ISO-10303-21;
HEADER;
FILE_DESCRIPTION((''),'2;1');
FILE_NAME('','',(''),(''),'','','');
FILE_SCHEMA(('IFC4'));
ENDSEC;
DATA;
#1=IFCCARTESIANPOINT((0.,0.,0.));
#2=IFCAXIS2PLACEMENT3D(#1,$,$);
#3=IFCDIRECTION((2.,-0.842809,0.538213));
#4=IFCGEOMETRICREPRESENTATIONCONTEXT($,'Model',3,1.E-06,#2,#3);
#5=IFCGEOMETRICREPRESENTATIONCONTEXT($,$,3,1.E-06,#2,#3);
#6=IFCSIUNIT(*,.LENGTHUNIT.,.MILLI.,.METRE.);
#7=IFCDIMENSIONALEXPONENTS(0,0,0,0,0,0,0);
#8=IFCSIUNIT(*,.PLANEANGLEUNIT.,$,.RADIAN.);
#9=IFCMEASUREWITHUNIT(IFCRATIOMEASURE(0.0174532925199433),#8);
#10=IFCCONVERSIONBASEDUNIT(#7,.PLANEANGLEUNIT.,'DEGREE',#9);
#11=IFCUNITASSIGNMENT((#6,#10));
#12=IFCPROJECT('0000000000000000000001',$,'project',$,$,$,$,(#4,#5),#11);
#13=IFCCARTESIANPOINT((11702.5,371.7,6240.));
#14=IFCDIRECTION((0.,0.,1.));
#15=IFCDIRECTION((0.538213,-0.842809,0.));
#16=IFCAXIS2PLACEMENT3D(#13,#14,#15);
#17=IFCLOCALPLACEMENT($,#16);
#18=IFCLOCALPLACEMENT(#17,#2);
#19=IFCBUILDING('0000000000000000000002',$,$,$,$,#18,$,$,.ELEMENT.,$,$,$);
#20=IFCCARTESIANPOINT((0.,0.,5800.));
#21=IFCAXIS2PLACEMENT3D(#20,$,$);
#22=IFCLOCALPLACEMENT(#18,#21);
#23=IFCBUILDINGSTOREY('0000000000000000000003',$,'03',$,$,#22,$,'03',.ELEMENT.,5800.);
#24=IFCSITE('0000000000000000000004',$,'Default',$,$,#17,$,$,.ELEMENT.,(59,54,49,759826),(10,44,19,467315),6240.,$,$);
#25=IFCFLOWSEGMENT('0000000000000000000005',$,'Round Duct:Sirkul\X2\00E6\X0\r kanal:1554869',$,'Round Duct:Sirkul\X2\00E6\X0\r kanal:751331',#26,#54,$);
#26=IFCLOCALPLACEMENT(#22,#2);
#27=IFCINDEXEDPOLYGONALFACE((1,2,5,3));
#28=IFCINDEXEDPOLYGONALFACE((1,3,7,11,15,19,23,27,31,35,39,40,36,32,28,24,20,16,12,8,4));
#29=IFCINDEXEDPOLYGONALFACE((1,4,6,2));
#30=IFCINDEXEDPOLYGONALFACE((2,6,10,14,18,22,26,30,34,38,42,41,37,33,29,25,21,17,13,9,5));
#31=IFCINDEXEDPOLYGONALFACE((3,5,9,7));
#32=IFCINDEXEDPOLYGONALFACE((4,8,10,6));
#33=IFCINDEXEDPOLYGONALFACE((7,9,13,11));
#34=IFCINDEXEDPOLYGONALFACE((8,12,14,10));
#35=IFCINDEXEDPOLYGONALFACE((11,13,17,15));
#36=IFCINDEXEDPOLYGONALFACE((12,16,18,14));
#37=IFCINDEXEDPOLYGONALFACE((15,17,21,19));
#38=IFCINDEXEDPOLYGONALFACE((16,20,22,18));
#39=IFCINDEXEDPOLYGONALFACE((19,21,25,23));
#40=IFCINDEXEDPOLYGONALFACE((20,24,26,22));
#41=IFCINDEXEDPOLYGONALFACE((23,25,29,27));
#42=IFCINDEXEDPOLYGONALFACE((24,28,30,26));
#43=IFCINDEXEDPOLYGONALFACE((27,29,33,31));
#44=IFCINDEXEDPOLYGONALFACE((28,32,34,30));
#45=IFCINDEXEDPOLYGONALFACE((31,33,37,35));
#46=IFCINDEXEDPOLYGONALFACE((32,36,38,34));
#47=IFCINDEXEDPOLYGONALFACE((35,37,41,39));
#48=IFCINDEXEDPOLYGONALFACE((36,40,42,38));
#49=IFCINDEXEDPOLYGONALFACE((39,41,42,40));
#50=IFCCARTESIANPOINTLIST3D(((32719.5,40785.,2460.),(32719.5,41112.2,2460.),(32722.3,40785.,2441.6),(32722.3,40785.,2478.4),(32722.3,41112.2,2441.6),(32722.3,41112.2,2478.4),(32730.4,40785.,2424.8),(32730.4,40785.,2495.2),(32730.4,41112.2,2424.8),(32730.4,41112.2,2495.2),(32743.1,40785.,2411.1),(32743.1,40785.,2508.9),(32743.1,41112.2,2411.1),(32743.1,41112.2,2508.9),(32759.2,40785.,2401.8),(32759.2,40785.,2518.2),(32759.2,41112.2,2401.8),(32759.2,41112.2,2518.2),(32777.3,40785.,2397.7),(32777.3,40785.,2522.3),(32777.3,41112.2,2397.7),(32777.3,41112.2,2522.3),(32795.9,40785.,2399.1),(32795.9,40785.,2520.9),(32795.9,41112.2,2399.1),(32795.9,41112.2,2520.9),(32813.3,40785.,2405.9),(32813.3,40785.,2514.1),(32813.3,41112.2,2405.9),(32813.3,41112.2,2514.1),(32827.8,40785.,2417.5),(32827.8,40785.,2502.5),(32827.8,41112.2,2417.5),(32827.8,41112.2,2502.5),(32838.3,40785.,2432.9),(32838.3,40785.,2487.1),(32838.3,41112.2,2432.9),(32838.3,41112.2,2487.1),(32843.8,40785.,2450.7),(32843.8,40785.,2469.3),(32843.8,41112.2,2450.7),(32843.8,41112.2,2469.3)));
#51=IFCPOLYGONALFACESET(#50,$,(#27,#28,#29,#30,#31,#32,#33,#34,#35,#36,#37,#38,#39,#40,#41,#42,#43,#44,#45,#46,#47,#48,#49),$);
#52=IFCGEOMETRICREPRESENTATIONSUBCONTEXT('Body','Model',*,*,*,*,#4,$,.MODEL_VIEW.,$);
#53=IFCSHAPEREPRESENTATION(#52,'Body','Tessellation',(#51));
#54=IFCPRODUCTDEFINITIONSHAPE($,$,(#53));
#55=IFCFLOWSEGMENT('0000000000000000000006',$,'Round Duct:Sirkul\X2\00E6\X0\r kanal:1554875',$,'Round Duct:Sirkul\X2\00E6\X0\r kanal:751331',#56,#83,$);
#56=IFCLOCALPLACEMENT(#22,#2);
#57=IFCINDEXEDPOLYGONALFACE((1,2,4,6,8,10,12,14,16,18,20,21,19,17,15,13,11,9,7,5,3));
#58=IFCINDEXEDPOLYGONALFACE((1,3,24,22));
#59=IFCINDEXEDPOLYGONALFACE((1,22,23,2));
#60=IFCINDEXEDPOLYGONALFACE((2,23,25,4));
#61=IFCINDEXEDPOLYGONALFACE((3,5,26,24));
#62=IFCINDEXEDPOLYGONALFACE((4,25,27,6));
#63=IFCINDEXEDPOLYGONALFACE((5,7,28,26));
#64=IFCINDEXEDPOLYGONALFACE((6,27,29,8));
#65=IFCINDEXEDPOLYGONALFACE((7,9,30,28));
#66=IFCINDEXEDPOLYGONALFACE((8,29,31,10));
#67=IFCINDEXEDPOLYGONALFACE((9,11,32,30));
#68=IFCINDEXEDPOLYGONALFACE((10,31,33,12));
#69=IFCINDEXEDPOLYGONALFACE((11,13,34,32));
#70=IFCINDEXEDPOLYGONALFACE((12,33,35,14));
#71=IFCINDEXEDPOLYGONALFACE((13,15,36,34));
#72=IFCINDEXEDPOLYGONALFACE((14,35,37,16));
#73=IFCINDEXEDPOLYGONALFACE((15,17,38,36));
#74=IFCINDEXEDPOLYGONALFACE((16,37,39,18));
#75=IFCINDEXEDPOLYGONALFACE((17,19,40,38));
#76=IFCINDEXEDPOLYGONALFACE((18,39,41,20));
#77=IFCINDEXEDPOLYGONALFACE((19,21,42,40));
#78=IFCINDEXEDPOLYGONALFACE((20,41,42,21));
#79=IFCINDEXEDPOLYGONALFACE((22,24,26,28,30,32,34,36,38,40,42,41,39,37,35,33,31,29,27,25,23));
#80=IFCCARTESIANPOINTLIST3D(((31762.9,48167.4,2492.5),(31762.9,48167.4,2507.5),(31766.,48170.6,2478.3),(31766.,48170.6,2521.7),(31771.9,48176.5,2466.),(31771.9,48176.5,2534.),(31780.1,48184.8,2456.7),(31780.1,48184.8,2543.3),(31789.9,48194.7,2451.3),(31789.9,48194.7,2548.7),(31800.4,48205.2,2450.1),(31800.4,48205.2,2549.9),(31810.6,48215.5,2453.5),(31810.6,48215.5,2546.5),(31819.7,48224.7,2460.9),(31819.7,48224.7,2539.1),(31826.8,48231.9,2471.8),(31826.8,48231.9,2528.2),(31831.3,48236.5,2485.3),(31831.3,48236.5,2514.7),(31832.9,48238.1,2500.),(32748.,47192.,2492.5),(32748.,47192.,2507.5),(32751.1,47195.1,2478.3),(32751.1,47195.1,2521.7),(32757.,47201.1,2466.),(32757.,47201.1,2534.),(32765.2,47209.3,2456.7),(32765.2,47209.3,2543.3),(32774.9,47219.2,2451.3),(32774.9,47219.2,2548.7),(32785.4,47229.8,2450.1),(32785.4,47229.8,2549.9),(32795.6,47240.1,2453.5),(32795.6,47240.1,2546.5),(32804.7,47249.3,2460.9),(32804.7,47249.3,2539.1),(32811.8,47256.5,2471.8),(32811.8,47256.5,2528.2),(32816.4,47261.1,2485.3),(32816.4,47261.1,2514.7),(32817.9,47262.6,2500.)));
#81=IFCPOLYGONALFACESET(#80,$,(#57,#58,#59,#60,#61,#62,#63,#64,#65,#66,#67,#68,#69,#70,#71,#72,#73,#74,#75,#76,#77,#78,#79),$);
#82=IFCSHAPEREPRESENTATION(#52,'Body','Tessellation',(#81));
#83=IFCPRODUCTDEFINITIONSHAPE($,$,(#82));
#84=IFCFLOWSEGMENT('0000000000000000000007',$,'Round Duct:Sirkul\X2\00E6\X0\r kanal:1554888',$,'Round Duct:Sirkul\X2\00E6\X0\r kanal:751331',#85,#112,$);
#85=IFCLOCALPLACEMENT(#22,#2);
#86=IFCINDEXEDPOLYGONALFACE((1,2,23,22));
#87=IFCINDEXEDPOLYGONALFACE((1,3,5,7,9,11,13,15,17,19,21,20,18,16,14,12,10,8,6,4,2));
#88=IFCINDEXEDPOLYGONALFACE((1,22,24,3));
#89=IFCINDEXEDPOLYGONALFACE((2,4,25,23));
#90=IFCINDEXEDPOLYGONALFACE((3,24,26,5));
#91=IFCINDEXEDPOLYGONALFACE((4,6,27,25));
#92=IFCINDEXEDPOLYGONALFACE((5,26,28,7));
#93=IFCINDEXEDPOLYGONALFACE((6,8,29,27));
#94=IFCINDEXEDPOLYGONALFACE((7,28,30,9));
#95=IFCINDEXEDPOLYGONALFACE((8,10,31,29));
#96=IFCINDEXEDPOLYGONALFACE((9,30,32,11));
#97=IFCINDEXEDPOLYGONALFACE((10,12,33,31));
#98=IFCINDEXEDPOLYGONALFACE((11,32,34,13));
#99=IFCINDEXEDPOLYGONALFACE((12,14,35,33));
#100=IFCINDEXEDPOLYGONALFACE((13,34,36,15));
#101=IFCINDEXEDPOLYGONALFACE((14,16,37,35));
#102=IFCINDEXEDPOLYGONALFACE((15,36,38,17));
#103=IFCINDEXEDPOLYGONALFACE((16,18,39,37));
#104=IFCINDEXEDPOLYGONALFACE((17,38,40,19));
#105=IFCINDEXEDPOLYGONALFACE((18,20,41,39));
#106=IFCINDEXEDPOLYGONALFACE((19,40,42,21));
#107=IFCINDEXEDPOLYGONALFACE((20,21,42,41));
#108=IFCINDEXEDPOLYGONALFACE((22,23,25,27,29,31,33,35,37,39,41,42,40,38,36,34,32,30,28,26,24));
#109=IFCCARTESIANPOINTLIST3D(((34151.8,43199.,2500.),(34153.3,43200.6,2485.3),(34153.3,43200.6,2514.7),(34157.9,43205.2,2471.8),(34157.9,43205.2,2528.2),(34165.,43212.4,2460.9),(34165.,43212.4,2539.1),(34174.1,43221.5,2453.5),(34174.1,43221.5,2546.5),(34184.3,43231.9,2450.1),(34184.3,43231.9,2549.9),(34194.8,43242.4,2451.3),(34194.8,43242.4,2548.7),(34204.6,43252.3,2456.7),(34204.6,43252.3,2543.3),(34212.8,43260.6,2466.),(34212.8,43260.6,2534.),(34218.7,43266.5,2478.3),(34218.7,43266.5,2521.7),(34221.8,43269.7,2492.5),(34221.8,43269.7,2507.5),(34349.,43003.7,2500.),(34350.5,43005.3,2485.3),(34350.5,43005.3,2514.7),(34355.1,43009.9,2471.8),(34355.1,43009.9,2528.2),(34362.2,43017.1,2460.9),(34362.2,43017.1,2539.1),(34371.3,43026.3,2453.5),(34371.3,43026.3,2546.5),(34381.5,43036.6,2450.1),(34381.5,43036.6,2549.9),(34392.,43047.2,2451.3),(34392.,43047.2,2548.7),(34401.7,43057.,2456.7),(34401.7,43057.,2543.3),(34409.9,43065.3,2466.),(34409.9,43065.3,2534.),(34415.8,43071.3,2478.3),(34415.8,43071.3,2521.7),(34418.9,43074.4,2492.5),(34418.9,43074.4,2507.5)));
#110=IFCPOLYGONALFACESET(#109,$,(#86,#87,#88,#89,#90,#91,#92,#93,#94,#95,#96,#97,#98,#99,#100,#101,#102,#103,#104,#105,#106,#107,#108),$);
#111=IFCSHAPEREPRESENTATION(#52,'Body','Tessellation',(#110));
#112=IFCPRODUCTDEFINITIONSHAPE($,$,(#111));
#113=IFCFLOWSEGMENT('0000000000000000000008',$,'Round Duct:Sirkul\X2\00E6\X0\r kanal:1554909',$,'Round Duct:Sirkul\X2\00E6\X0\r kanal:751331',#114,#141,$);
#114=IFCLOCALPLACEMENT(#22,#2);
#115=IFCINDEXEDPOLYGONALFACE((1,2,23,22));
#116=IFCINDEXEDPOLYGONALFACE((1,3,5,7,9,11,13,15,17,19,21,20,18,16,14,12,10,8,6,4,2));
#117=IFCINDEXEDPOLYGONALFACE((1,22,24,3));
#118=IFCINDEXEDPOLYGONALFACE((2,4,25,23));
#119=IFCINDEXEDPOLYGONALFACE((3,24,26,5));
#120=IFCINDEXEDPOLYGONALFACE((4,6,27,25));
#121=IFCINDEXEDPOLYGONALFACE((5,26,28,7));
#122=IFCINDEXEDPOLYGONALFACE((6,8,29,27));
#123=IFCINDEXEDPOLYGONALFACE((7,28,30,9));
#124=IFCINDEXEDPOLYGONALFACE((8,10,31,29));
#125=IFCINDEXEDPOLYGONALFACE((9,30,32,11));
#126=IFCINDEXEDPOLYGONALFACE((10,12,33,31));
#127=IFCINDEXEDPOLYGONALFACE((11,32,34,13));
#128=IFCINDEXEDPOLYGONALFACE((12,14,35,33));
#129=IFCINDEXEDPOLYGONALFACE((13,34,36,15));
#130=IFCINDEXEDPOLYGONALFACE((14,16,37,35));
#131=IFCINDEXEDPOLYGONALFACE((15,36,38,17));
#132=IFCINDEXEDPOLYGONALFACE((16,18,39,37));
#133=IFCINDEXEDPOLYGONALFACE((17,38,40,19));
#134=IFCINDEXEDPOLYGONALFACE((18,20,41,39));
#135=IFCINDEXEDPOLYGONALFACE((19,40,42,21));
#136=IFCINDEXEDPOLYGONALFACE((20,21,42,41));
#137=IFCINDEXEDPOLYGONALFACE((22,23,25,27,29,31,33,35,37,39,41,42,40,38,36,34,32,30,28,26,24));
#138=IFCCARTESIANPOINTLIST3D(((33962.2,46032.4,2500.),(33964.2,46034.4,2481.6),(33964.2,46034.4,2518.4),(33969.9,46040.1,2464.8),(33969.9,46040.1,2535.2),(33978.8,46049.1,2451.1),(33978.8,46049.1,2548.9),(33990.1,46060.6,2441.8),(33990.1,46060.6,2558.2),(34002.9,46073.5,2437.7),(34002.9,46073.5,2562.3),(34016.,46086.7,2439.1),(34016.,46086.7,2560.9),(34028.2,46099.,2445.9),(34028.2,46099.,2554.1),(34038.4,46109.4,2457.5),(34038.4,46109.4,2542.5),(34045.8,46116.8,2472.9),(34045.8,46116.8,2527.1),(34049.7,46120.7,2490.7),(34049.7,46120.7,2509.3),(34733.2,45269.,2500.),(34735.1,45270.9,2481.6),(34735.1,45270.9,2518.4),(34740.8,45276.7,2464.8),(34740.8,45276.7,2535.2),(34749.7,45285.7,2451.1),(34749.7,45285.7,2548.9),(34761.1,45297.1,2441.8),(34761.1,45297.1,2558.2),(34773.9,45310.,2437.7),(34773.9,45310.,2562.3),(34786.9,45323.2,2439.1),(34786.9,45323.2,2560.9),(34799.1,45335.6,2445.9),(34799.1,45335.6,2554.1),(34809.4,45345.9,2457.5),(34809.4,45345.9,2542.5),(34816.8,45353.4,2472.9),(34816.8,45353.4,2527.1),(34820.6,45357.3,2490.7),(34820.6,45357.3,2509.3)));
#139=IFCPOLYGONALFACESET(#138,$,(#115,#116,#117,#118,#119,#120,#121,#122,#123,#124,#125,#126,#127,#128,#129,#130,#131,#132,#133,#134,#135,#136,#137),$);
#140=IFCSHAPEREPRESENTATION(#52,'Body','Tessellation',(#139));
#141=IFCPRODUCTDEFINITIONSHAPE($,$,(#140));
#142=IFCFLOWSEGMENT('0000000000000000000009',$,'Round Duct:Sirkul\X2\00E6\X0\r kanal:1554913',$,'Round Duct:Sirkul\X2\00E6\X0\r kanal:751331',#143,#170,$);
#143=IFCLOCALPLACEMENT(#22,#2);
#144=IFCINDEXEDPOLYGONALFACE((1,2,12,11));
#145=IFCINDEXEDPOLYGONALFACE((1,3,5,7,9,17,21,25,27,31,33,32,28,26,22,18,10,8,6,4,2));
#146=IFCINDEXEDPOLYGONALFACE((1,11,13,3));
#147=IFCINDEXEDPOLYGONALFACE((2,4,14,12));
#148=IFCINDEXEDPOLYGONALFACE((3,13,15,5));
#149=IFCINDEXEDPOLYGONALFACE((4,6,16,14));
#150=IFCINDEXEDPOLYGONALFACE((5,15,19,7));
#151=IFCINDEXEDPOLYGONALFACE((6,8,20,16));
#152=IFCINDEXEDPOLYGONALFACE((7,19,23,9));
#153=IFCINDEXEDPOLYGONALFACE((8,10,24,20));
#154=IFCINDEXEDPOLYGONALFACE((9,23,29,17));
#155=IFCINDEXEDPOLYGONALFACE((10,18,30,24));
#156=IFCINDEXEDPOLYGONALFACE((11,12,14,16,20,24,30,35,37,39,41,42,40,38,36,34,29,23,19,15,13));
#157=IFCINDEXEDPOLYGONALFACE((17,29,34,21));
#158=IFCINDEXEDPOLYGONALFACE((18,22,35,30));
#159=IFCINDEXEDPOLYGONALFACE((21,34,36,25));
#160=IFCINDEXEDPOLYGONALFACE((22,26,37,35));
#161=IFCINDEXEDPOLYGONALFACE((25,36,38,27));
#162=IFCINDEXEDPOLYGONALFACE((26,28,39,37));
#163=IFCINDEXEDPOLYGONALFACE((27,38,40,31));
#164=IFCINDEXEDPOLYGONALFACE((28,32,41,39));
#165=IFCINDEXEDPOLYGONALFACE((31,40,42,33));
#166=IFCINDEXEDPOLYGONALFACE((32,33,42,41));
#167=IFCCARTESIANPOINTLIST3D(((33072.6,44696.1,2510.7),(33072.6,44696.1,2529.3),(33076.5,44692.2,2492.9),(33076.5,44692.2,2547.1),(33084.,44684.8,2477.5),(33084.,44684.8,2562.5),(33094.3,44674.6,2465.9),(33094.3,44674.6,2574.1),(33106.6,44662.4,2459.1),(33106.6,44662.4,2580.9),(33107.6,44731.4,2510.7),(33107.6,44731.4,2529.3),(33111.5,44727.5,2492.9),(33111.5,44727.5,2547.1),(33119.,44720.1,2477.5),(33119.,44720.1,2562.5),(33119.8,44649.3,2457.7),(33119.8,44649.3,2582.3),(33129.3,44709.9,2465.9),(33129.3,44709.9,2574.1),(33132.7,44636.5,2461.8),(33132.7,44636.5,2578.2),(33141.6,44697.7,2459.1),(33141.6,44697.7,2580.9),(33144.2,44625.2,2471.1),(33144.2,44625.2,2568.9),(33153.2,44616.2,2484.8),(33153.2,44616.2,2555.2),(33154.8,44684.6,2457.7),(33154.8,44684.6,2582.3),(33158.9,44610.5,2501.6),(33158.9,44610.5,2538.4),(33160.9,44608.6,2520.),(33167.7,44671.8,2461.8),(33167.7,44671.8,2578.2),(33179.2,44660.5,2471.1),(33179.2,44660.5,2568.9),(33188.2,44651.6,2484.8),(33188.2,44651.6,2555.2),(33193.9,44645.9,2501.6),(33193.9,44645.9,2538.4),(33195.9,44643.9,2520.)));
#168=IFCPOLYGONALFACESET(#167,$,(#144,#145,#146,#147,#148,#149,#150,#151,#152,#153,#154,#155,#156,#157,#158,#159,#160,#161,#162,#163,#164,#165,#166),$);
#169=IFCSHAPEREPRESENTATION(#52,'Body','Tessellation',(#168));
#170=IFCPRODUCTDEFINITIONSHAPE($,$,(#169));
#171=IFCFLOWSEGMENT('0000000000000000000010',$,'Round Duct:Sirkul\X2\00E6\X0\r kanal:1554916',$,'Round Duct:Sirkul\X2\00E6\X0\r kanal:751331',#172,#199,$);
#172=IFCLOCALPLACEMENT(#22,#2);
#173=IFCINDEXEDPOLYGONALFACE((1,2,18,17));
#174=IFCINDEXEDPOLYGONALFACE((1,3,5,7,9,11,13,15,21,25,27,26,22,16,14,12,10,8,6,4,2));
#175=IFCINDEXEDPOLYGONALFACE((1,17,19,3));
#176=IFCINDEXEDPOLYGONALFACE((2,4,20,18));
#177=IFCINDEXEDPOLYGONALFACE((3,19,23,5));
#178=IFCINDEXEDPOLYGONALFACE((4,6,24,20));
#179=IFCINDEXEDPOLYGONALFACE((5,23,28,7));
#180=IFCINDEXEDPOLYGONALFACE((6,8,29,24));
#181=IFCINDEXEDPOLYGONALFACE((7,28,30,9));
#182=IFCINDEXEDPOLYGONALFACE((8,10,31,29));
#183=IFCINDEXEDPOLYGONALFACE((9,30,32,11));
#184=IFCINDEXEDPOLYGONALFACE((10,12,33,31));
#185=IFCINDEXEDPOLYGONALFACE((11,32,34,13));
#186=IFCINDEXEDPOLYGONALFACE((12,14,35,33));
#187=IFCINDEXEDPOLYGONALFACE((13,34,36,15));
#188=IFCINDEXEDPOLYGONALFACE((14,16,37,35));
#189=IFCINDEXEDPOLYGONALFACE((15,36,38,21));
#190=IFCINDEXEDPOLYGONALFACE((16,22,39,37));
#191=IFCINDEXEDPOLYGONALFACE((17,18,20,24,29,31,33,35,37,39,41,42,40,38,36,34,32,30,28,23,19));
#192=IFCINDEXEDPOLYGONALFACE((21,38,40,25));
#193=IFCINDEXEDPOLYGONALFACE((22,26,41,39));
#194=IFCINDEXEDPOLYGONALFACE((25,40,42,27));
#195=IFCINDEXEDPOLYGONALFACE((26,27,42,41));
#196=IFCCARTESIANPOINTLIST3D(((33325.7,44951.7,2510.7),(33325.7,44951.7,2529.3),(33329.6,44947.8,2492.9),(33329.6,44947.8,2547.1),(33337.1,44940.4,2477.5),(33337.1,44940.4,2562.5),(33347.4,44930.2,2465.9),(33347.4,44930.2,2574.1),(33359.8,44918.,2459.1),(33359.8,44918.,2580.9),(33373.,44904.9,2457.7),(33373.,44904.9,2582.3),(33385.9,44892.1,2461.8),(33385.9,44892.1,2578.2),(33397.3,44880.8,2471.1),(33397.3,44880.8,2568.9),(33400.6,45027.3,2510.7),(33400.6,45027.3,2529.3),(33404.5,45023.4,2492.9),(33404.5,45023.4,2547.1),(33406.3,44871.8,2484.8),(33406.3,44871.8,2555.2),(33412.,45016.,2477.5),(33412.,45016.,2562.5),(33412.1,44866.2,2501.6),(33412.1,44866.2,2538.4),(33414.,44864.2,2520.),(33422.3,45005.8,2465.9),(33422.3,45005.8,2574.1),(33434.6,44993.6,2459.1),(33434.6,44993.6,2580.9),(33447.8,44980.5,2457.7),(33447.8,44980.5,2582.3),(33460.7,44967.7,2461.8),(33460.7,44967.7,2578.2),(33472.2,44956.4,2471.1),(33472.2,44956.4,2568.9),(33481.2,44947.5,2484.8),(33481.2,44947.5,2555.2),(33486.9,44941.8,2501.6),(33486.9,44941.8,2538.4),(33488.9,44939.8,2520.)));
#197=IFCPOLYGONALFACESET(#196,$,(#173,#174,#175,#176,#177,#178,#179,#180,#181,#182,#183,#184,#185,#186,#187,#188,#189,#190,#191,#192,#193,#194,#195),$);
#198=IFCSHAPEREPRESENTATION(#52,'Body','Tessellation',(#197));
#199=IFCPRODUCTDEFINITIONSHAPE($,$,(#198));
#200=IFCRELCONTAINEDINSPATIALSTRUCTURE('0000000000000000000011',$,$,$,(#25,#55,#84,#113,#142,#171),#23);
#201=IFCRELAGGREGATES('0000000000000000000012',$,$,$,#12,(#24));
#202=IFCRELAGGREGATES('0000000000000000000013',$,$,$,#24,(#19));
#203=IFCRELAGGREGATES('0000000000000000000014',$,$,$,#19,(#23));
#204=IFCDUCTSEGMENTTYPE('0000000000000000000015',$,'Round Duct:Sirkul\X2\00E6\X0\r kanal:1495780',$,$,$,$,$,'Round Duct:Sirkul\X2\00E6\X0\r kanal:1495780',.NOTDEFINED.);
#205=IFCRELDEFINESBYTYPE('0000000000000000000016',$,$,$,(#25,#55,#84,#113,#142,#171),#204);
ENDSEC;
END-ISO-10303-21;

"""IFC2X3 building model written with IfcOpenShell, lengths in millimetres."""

from ifc_helpers import new_model, entity, si_unit, converted_unit, direction, frame, frame_2d, origin, origin_2d_with_axis, place, context, subcontext, project, spatial, circle, extrude, type_object, element, save


model = new_model("IFC2X3")

# Units and contexts
model_context = context("Model", 3, precision=1e-06, world=origin(), true_north=direction((2.0, -0.842809, 0.538213)))
context_of_model = context(None, 3, precision=1e-06, world=origin(), true_north=direction((2.0, -0.842809, 0.538213)))
body_context = subcontext(model_context, "Body", "Model", "MODEL_VIEW")
ifc_project = project(units=[si_unit("LENGTHUNIT", "METRE", prefix="MILLI"), converted_unit("PLANEANGLEUNIT", "DEGREE", entity("IfcRatioMeasure", 0.0174532925199433), si_unit("PLANEANGLEUNIT", "RADIAN"), dimensions=[0, 0, 0, 0, 0, 0, 0])], contexts=[model_context, context_of_model])

# Site, building, storey
site_placement = place(None, frame((11702.5, 371.7, 6240.0), z_axis=(0.0, 0.0, 1.0), x_axis=(0.538213, -0.842809, 0.0)))
site = spatial("IfcSite", under=ifc_project, at=site_placement, Name="Default", CompositionType="ELEMENT", RefLatitude=(59, 54, 49, 759826), RefLongitude=(10, 44, 19, 467315), RefElevation=6240.0)
building_placement = place(site_placement, origin())
building = spatial("IfcBuilding", under=site, at=building_placement, CompositionType="ELEMENT")
storey_placement = place(building_placement, frame((0.0, 0.0, 5800.0)))
storey = spatial("IfcBuildingStorey", under=building, at=storey_placement, Name="03", LongName="03", CompositionType="ELEMENT", Elevation=5800.0)

# Flow segments
duct_segment_type_1 = type_object("IfcDuctSegmentType", Name="Round Duct:Sirkulær kanal:1495780", ElementType="Round Duct:Sirkulær kanal:1495780", PredefinedType="NOTDEFINED")
flow_segment_1_placement = place(storey_placement, origin())
element("IfcFlowSegment", 1, at=flow_segment_1_placement, inside=storey, type_object=duct_segment_type_1, Name="Round Duct:Sirkulær kanal:1554869", ObjectType="Round Duct:Sirkulær kanal:751331", context=body_context, shape_type="SweptSolid", body=[
    extrude(circle(Radius=62.5, at=frame_2d((0.0, 0.0), x_axis=(1.0, 0.0))), frame((32782.0, 40785.0, 2460.0), z_axis=(0.0, 1.0, 0.0), x_axis=(-1.0, 0.0, 0.0)), (0.0, 0.0, 1.0), 327.2),
])
flow_segment_2_placement = place(storey_placement, origin())
element("IfcFlowSegment", 2, at=flow_segment_2_placement, inside=storey, type_object=duct_segment_type_1, Name="Round Duct:Sirkulær kanal:1554875", ObjectType="Round Duct:Sirkulær kanal:751331", context=body_context, shape_type="SweptSolid", body=[
    extrude(circle(Radius=50.0, at=frame_2d((0.0, 0.0), x_axis=(1.0, 0.0))), frame((32782.8, 47227.1, 2500.0), z_axis=(-0.710554, 0.703643, 0.0), x_axis=(0.703643, 0.710554, 0.0)), (0.0, 0.0, 1.0), 1386.3),
])
flow_segment_3_placement = place(storey_placement, origin())
element("IfcFlowSegment", 3, at=flow_segment_3_placement, inside=storey, type_object=duct_segment_type_1, Name="Round Duct:Sirkulær kanal:1554888", ObjectType="Round Duct:Sirkulær kanal:751331", context=body_context, shape_type="SweptSolid", body=[
    extrude(circle(Radius=50.0, at=frame_2d((0.0, 0.0), x_axis=(1.0, 0.0))), frame((34187.0, 43234.5, 2500.0), z_axis=(0.710554, -0.703643, 0.0), x_axis=(-0.703643, -0.710554, 0.0)), (0.0, 0.0, 1.0), 277.5),
])
flow_segment_4_placement = place(storey_placement, origin())
element("IfcFlowSegment", 4, at=flow_segment_4_placement, inside=storey, type_object=duct_segment_type_1, Name="Round Duct:Sirkulær kanal:1554909", ObjectType="Round Duct:Sirkulær kanal:751331", context=body_context, shape_type="SweptSolid", body=[
    extrude(circle(Radius=62.5, at=origin_2d_with_axis()), frame((34006.2, 46076.8, 2500.0), z_axis=(0.710554, -0.703643, 0.0), x_axis=(-0.703643, -0.710554, 0.0)), (0.0, 0.0, 1.0), 1085.0),
])
flow_segment_5_placement = place(storey_placement, origin())
element("IfcFlowSegment", 5, at=flow_segment_5_placement, inside=storey, type_object=duct_segment_type_1, Name="Round Duct:Sirkulær kanal:1554913", ObjectType="Round Duct:Sirkulær kanal:751331", context=body_context, shape_type="SweptSolid", body=[
    extrude(circle(Radius=62.5, at=origin_2d_with_axis()), frame((33116.5, 44652.6, 2520.0), z_axis=(0.703643, 0.710554, 0.0), x_axis=(0.710554, -0.703643, 0.0)), (0.0, 0.0, 1.0), 49.7),
])
flow_segment_6_placement = place(storey_placement, origin())
element("IfcFlowSegment", 6, at=flow_segment_6_placement, inside=storey, type_object=duct_segment_type_1, Name="Round Duct:Sirkulær kanal:1554916", ObjectType="Round Duct:Sirkulær kanal:751331", context=body_context, shape_type="SweptSolid", body=[
    extrude(circle(Radius=62.5, at=origin_2d_with_axis()), frame((33369.6, 44908.2, 2520.0), z_axis=(0.703643, 0.710554, 0.0), x_axis=(0.710554, -0.703643, 0.0)), (0.0, 0.0, 1.0), 106.4),
])

save(model, "model.ifc")
